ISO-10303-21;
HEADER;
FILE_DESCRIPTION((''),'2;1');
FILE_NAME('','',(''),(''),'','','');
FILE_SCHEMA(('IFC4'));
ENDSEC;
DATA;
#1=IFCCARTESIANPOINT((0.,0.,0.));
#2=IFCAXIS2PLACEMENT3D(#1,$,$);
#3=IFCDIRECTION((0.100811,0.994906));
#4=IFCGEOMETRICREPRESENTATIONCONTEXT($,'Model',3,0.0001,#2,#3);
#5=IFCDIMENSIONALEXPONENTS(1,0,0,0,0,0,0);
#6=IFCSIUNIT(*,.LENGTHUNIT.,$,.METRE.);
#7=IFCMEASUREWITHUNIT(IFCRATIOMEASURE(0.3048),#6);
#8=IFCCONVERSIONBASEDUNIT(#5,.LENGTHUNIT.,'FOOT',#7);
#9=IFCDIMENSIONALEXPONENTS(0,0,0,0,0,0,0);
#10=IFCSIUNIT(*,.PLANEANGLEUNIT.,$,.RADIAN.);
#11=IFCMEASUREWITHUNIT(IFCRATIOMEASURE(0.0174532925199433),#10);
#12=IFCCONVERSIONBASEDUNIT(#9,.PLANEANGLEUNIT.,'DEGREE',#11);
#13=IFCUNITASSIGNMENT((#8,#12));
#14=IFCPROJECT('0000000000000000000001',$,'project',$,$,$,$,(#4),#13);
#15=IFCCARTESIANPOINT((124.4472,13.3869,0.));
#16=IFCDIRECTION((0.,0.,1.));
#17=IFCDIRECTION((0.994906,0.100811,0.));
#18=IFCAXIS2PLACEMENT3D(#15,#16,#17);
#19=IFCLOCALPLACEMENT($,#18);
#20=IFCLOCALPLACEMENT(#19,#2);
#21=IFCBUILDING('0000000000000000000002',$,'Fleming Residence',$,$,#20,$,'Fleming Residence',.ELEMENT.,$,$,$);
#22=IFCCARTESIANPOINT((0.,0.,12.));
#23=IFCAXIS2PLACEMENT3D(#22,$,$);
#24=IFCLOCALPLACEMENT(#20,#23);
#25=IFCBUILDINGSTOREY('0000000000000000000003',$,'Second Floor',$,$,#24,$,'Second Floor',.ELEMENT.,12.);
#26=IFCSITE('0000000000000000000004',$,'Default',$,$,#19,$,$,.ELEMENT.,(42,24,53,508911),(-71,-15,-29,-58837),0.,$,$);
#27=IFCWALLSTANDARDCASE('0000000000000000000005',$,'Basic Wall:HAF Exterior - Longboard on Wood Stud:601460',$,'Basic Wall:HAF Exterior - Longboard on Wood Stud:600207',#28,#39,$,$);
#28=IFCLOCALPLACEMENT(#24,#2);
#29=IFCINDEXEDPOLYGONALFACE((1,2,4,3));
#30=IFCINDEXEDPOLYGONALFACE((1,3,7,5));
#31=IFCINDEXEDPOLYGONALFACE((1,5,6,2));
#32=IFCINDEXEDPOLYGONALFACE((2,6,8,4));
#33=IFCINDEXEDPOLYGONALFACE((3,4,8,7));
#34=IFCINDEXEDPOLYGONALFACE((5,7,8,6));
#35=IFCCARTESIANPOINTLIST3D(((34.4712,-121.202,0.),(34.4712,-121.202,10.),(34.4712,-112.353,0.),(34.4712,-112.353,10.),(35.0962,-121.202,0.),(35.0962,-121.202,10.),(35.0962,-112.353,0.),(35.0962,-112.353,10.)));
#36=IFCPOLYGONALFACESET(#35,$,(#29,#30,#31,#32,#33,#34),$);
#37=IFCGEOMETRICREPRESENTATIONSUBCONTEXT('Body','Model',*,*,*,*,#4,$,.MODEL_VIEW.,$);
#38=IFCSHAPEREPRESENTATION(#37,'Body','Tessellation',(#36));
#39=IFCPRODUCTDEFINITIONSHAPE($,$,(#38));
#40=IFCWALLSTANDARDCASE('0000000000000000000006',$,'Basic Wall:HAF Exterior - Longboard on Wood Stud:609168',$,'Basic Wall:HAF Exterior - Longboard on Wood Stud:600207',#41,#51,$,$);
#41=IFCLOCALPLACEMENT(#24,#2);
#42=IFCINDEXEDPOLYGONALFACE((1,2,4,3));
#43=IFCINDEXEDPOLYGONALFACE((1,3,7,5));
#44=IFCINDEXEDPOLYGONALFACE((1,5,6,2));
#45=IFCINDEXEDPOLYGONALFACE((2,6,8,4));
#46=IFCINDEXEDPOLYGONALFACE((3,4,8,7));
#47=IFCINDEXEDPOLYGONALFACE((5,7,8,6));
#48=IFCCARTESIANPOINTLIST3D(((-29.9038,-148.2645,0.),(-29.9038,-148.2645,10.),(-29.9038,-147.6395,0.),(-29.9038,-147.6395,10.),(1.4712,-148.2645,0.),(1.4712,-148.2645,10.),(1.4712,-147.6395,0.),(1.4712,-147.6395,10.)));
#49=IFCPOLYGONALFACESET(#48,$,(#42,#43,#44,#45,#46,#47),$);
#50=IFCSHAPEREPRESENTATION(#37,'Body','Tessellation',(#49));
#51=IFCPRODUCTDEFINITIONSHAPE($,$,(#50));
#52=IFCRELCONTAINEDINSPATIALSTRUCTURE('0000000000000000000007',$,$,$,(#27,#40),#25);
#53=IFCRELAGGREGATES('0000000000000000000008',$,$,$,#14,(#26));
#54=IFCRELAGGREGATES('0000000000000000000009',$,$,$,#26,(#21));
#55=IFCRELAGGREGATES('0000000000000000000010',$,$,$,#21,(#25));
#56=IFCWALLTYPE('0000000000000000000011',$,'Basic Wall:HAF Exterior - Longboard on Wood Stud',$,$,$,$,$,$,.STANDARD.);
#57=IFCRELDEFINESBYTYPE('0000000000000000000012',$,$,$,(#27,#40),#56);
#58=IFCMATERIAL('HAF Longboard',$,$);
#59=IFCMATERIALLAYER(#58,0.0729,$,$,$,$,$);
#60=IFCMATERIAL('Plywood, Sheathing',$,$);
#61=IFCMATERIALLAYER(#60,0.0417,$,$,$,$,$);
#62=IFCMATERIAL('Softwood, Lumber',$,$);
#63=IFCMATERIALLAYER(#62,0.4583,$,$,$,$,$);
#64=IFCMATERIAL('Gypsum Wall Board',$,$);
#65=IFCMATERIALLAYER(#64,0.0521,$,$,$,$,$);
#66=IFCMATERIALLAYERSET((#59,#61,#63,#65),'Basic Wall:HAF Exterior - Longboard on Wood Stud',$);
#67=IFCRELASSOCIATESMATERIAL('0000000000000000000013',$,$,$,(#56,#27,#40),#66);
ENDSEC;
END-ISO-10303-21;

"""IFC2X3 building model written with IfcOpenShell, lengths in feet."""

from ifc_helpers import new_model, entity, si_unit, converted_unit, direction, frame, frame_2d, origin, place, context, subcontext, project, spatial, polyline, rectangle, extrude, clip, bounded_halfspace, material, layer, layer_set, layer_usage, type_object, element, save


model = new_model("IFC2X3")

# Units and contexts
model_context = context("Model", 3, precision=0.0001, world=origin(), true_north=direction((0.100811, 0.994906)))
body_context = subcontext(model_context, "Body", "Model", "MODEL_VIEW")
ifc_project = project(units=[converted_unit("LENGTHUNIT", "FOOT", entity("IfcRatioMeasure", 0.3048), si_unit("LENGTHUNIT", "METRE"), dimensions=[1, 0, 0, 0, 0, 0, 0]), converted_unit("PLANEANGLEUNIT", "DEGREE", entity("IfcRatioMeasure", 0.0174532925199433), si_unit("PLANEANGLEUNIT", "RADIAN"), dimensions=[0, 0, 0, 0, 0, 0, 0])], contexts=[model_context])

# Site, building, storey
site_placement = place(None, frame((124.4472, 13.3869, 0.0), z_axis=(0.0, 0.0, 1.0), x_axis=(0.994906, 0.100811, 0.0)))
site = spatial("IfcSite", under=ifc_project, at=site_placement, Name="Default", CompositionType="ELEMENT", RefLatitude=(42, 24, 53, 508911), RefLongitude=(-71, -15, -29, -58837), RefElevation=0.0)
building_placement = place(site_placement, origin())
building = spatial("IfcBuilding", under=site, at=building_placement, Name="Fleming Residence", LongName="Fleming Residence", CompositionType="ELEMENT")
storey_placement = place(building_placement, frame((0.0, 0.0, 12.0)))
storey = spatial("IfcBuildingStorey", under=building, at=storey_placement, Name="Second Floor", LongName="Second Floor", CompositionType="ELEMENT", Elevation=12.0)

# Walls
ifc_material_1 = material(Name="Plywood, Sheathing")
ifc_material_2 = material(Name="Softwood, Lumber")
ifc_material_3 = material(Name="Gypsum Wall Board")
ifc_material_4 = material(Name="HAF Longboard")
ifc_layer_1 = layer(ifc_material_4, 0.0729)
ifc_layer_2 = layer(ifc_material_1, 0.0417)
ifc_layer_3 = layer(ifc_material_2, 0.4583)
ifc_layer_4 = layer(ifc_material_3, 0.0521)
ifc_layer_set_1 = layer_set([ifc_layer_1, ifc_layer_2, ifc_layer_3, ifc_layer_4], Name="Basic Wall:HAF Exterior - Longboard on Wood Stud")
wall_type_1 = type_object("IfcWallType", Name="Basic Wall:HAF Exterior - Longboard on Wood Stud", PredefinedType="STANDARD", material=ifc_layer_set_1)
ifc_layer_usage_1 = layer_usage(ifc_layer_set_1, "AXIS2", "NEGATIVE", 0.3125)
wall_1_placement = place(storey_placement, frame((34.7837, -121.202, 0.0), z_axis=(0.0, 0.0, 1.0), x_axis=(0.0, 1.0, 0.0)))
element("IfcWallStandardCase", 1, at=wall_1_placement, inside=storey, type_object=wall_type_1, material=ifc_layer_usage_1, Name="Basic Wall:HAF Exterior - Longboard on Wood Stud:601460", ObjectType="Basic Wall:HAF Exterior - Longboard on Wood Stud:600207", context=body_context, shape_type="Clipping", body=[
    clip(extrude(rectangle(XDim=8.849, YDim=0.625, at=frame_2d((4.4245, 0.0), x_axis=(-1.0, 0.0))), origin(), (0.0, 0.0, 1.0), 10.0), bounded_halfspace(frame((0.0, -0.3125, 10.0), z_axis=(0.0, 0.0, -1.0), x_axis=(0.0, 1.0, 0.0)), True, frame((0.0, -0.3125, 10.0)), polyline([(0.0, 0.0), (5.1146, 0.0), (5.5104, 0.0), (8.849, 0.0), (8.849, 0.625), (0.0, 0.625), (0.0, 0.0)]))),
])
ifc_layer_usage_2 = layer_usage(ifc_layer_set_1, "AXIS2", "NEGATIVE", 0.3125)
wall_2_placement = place(storey_placement, frame((1.4712, -147.952, 0.0), z_axis=(0.0, 0.0, 1.0), x_axis=(-1.0, 0.0, 0.0)))
element("IfcWallStandardCase", 2, at=wall_2_placement, inside=storey, type_object=wall_type_1, material=ifc_layer_usage_2, Name="Basic Wall:HAF Exterior - Longboard on Wood Stud:609168", ObjectType="Basic Wall:HAF Exterior - Longboard on Wood Stud:600207", context=body_context, shape_type="Clipping", body=[
    clip(extrude(rectangle(XDim=31.375, YDim=0.625, at=frame_2d((15.6875, 0.0), x_axis=(-1.0, 0.0))), origin(), (0.0, 0.0, 1.0), 10.0), bounded_halfspace(frame((0.0, -0.3125, 10.0), z_axis=(0.0, 0.0, -1.0), x_axis=(0.0, 1.0, 0.0)), True, frame((0.0, -0.3125, 10.0)), polyline([(0.0, 0.0), (0.5625, 0.0), (0.625, 0.0), (7.2292, 0.0), (7.625, 0.0), (31.375, 0.0), (31.375, 0.625), (0.625, 0.625), (0.0, 0.625), (0.0, 0.0)]))),
])

save(model, "model.ifc")
